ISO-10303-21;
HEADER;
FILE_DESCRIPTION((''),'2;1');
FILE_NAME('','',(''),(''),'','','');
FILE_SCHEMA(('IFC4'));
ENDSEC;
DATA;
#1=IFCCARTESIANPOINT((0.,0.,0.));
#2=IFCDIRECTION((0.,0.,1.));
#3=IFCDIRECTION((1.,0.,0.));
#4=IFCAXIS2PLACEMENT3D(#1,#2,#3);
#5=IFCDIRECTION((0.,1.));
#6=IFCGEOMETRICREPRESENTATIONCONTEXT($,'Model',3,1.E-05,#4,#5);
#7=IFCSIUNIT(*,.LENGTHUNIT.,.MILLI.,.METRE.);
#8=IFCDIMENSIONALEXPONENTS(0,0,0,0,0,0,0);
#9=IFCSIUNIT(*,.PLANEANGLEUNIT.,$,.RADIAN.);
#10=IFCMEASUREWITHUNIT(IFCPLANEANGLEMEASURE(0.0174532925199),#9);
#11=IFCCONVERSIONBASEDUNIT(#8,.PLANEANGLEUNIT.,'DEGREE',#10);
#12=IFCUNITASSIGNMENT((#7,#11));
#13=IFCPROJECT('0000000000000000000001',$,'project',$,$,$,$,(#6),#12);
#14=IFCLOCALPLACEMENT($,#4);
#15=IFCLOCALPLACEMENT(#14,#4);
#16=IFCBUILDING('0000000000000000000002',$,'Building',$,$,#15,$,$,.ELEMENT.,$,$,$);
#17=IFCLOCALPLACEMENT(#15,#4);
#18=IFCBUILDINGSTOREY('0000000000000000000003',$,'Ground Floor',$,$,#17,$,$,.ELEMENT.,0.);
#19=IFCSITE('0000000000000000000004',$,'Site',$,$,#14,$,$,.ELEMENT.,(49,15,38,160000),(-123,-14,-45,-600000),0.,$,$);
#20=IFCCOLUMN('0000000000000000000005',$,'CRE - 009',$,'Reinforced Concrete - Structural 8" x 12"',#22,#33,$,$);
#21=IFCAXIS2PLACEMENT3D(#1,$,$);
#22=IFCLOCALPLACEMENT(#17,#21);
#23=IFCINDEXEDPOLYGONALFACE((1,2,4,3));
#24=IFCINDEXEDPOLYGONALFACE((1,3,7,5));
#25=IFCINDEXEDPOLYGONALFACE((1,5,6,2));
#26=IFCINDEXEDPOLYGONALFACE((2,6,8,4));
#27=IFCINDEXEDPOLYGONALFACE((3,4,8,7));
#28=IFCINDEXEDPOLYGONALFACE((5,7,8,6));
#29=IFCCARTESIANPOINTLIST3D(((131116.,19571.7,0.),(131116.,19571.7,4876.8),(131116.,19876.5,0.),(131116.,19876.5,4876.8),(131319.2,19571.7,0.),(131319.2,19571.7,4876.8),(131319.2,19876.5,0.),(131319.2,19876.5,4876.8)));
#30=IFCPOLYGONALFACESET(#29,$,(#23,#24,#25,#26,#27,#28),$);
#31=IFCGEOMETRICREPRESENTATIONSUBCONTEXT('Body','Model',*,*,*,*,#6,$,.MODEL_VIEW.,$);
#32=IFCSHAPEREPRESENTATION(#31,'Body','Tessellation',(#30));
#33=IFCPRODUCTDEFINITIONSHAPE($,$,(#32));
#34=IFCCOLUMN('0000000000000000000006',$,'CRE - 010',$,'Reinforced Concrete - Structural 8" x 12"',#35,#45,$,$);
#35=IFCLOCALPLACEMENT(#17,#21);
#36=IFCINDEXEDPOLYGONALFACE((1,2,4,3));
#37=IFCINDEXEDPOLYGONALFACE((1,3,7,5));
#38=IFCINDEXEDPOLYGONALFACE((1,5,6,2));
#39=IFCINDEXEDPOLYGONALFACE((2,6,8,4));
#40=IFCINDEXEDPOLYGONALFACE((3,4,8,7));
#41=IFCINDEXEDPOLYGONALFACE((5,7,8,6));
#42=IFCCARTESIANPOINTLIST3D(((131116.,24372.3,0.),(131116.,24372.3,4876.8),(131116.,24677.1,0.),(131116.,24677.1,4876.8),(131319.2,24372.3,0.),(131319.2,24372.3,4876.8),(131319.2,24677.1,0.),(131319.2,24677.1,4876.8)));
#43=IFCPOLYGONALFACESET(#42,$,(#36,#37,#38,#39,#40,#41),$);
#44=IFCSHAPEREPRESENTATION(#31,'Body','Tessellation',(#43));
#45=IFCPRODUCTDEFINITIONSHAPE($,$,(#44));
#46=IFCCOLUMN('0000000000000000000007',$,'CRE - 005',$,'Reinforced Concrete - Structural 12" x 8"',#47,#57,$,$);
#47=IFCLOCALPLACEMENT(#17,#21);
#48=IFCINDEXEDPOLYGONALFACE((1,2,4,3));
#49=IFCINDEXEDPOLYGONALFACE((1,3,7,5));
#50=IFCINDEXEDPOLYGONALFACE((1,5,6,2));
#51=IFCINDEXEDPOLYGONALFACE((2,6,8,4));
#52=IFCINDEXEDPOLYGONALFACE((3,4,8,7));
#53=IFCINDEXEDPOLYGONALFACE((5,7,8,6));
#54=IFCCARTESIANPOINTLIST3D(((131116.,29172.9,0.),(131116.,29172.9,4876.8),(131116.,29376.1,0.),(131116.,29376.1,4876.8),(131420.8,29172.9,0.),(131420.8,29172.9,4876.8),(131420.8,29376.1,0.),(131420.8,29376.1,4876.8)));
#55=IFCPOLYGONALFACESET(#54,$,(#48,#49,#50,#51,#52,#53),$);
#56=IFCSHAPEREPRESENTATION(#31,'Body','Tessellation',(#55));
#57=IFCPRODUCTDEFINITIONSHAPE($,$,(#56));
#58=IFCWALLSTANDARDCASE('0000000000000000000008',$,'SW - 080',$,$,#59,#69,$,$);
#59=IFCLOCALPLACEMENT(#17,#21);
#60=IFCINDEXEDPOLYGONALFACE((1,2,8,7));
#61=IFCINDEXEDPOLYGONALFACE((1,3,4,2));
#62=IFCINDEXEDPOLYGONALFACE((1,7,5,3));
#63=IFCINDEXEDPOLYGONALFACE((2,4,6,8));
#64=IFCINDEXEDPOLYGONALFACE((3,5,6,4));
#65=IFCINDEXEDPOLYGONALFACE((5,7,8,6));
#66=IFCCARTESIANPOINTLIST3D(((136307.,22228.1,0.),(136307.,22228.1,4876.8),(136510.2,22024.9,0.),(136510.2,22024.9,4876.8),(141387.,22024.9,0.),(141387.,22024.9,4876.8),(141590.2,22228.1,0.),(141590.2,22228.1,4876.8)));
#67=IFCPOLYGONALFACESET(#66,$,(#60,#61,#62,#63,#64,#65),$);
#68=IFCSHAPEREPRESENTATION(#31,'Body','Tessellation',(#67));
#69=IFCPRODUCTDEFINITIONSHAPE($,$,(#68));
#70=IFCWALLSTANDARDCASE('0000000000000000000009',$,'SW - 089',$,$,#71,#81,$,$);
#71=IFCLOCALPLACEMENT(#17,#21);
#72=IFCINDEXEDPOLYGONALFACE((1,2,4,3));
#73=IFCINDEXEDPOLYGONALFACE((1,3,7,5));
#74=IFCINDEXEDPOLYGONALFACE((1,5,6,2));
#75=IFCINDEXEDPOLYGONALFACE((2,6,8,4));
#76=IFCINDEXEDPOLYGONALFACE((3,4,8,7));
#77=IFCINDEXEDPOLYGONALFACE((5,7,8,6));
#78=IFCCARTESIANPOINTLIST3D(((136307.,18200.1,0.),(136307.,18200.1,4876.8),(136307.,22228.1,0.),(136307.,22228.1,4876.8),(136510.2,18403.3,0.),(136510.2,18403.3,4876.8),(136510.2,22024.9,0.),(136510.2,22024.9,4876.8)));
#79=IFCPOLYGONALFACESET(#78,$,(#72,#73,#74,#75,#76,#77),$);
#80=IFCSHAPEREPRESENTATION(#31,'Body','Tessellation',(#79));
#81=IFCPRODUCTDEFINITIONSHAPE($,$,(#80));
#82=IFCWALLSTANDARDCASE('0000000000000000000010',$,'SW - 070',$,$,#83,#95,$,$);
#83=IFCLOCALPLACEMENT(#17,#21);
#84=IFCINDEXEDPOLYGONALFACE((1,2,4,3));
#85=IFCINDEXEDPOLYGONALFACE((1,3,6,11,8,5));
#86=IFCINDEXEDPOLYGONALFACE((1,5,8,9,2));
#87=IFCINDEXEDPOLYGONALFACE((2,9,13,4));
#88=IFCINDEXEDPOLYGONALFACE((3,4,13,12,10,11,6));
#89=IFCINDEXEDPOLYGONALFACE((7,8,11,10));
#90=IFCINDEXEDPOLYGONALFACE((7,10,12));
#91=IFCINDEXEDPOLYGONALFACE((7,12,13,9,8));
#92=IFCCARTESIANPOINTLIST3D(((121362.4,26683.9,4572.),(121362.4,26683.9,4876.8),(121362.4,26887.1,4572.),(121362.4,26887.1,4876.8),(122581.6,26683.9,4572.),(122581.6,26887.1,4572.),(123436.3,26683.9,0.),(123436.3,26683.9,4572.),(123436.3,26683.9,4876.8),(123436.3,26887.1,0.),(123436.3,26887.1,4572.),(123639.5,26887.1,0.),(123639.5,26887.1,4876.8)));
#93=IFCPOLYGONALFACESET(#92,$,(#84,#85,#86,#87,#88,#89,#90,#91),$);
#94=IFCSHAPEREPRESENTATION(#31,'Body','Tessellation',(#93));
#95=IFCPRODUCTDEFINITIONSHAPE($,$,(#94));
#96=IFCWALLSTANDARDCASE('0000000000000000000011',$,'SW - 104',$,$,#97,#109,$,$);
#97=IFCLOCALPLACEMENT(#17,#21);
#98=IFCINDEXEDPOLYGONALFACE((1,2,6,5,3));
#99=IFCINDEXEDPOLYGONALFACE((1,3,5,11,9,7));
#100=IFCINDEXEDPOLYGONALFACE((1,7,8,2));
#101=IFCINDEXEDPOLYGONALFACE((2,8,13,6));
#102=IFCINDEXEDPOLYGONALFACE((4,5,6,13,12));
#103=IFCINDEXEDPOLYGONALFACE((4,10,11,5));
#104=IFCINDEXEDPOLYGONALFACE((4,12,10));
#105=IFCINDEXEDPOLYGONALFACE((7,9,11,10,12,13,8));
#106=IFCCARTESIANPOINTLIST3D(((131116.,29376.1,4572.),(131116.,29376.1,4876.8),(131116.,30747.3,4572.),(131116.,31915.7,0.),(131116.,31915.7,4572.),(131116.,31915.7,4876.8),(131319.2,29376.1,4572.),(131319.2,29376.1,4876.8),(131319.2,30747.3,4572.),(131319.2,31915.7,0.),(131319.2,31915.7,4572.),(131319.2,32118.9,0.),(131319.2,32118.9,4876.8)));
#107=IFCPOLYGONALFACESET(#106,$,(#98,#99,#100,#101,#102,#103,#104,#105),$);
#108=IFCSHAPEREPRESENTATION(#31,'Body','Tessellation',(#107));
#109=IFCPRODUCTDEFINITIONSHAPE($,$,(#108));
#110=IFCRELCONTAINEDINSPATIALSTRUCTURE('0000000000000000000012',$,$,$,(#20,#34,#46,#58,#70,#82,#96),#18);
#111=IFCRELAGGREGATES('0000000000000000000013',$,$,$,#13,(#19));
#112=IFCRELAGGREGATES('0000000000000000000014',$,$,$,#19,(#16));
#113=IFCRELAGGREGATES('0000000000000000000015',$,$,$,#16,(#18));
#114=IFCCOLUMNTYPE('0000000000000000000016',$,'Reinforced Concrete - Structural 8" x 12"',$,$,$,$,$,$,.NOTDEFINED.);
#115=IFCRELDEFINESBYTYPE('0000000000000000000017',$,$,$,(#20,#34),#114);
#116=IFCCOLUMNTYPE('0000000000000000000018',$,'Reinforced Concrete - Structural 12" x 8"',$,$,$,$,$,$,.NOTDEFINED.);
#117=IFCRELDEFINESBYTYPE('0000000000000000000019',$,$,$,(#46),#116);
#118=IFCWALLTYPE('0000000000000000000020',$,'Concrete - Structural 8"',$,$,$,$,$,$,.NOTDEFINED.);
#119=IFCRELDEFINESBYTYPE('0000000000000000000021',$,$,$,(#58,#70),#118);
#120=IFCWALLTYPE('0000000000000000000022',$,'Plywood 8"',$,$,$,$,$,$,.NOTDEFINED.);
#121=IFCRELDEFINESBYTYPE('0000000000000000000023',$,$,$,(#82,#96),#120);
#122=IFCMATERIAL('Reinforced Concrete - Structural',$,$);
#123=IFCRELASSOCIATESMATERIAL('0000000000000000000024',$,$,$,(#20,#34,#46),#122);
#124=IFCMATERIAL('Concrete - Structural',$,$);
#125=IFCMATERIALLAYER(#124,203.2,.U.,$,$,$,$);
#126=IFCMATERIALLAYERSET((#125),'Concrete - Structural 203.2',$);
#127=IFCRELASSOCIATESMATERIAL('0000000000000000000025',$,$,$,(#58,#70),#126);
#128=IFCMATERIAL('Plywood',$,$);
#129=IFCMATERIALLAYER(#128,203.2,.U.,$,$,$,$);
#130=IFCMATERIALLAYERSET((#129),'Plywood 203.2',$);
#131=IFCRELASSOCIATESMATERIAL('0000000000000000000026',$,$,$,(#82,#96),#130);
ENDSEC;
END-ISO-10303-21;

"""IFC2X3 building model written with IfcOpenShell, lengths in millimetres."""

from ifc_helpers import new_model, entity, si_unit, converted_unit, direction, frame, origin_with_axes, origin_2d_with_axis, place, context, subcontext, project, spatial, polyline, rectangle, outline, extrude, material, layer, layer_set, layer_usage, type_object, element, save


model = new_model("IFC2X3")

# Units and contexts
model_context = context("Model", 3, precision=1e-05, world=origin_with_axes(), true_north=direction((0.0, 1.0)))
body_context = subcontext(model_context, "Body", "Model", "MODEL_VIEW")
ifc_project = project(units=[si_unit("LENGTHUNIT", "METRE", prefix="MILLI"), converted_unit("PLANEANGLEUNIT", "DEGREE", entity("IfcPlaneAngleMeasure", 0.0174532925199), si_unit("PLANEANGLEUNIT", "RADIAN"), dimensions=[0, 0, 0, 0, 0, 0, 0])], contexts=[model_context])

# Site, building, storey
site_placement = place(None, origin_with_axes())
site = spatial("IfcSite", under=ifc_project, at=site_placement, Name="Site", CompositionType="ELEMENT", RefLatitude=(49, 15, 38, 160000), RefLongitude=(-123, -14, -45, -600000), RefElevation=0.0)
building_placement = place(site_placement, origin_with_axes())
building = spatial("IfcBuilding", under=site, at=building_placement, Name="Building", CompositionType="ELEMENT")
storey_placement = place(building_placement, origin_with_axes())
storey = spatial("IfcBuildingStorey", under=building, at=storey_placement, Name="Ground Floor", CompositionType="ELEMENT", Elevation=0.0)

# Columns
ifc_material_1 = material(Name="Reinforced Concrete - Structural")
column_type_1 = type_object("IfcColumnType", Name="Reinforced Concrete - Structural 8\" x 12\"", PredefinedType="NOTDEFINED")
for number, where, z_axis, x_axis, name in (
    (1, (131217.6, 19724.1, 0.0), (0.0, 0.0, 1.0), (1.0, 0.0, 0.0), "CRE - 009"),
    (2, (131217.6, 24524.7, 0.0), (0.0, 0.0, 1.0), (1.0, 0.0, 0.0), "CRE - 010"),
):
    element("IfcColumn", number, at=place(storey_placement, frame(where, z_axis=z_axis, x_axis=x_axis)), inside=storey, type_object=column_type_1, material=ifc_material_1, Name=name, ObjectType="Reinforced Concrete - Structural 8\" x 12\"", context=body_context, shape_type="SweptSolid", body=[
        extrude(rectangle(XDim=203.2, YDim=304.8, at=origin_2d_with_axis()), origin_with_axes(), (0.0, 0.0, 1.0), 4876.8),
    ])
column_type_2 = type_object("IfcColumnType", Name="Reinforced Concrete - Structural 12\" x 8\"", PredefinedType="NOTDEFINED")
column_placement = place(storey_placement, frame((131268.4, 29274.5, 0.0), z_axis=(0.0, 0.0, 1.0), x_axis=(1.0, 0.0, 0.0)))
element("IfcColumn", 3, at=column_placement, inside=storey, type_object=column_type_2, material=ifc_material_1, Name="CRE - 005", ObjectType="Reinforced Concrete - Structural 12\" x 8\"", context=body_context, shape_type="SweptSolid", body=[
    extrude(rectangle(XDim=304.8, YDim=203.2, at=origin_2d_with_axis()), origin_with_axes(), (0.0, 0.0, 1.0), 4876.8),
])

# Walls
ifc_material_2 = material(Name="Concrete - Structural")
ifc_layer_1 = layer(ifc_material_2, 203.2, ventilated="UNKNOWN")
ifc_layer_set_1 = layer_set([ifc_layer_1], Name="Concrete - Structural 203.2")
ifc_layer_usage_1 = layer_usage(ifc_layer_set_1, "AXIS2", "POSITIVE", 0.0)
wall_type_1 = type_object("IfcWallType", Name="Concrete - Structural 8\"", PredefinedType="NOTDEFINED")
wall_1_placement = place(storey_placement, frame((136510.2, 22024.9, 0.0), z_axis=(0.0, 0.0, 1.0), x_axis=(1.0, 0.0, 0.0)))
element("IfcWallStandardCase", 4, at=wall_1_placement, inside=storey, type_object=wall_type_1, material=ifc_layer_usage_1, Name="SW - 080", context=body_context, shape_type="SweptSolid", body=[
    extrude(outline(polyline([(0.0, 0.0), (4876.8, 0.0), (5080.0, 203.2), (-203.2, 203.2), (0.0, 0.0)])), origin_with_axes(), (0.0, 0.0, 1.0), 4876.8),
])
ifc_layer_usage_2 = layer_usage(ifc_layer_set_1, "AXIS2", "NEGATIVE", 0.0)
wall_2_placement = place(storey_placement, frame((136510.2, 22024.9, 0.0), z_axis=(0.0, 0.0, 1.0), x_axis=(0.0, -1.0, 0.0)))
element("IfcWallStandardCase", 5, at=wall_2_placement, inside=storey, type_object=wall_type_1, material=ifc_layer_usage_2, Name="SW - 089", context=body_context, shape_type="SweptSolid", body=[
    extrude(outline(polyline([(-203.2, -203.2), (3824.8, -203.2), (3621.6, 0.0), (0.0, 0.0), (-203.2, -203.2)])), origin_with_axes(), (0.0, 0.0, 1.0), 4876.8),
])

# Walls, openings
ifc_material_3 = material(Name="Plywood")
ifc_layer_2 = layer(ifc_material_3, 203.2, ventilated="UNKNOWN")
ifc_layer_set_2 = layer_set([ifc_layer_2], Name="Plywood 203.2")
ifc_layer_usage_3 = layer_usage(ifc_layer_set_2, "AXIS2", "POSITIVE", 0.0)
wall_type_2 = type_object("IfcWallType", Name="Plywood 8\"", PredefinedType="NOTDEFINED")
wall_3_placement = place(storey_placement, frame((123639.5, 26887.1, 0.0), z_axis=(0.0, 0.0, 1.0), x_axis=(-1.0, 0.0, 0.0)))
wall_3 = element("IfcWallStandardCase", 6, at=wall_3_placement, inside=storey, type_object=wall_type_2, material=ifc_layer_usage_3, Name="SW - 070", context=body_context, shape_type="SweptSolid", body=[
    extrude(outline(polyline([(0.0, 0.0), (2277.0, 0.0), (2277.0, 203.2), (203.2, 203.2), (0.0, 0.0)])), origin_with_axes(), (0.0, 0.0, 1.0), 4876.8),
])
opening_1_placement = place(wall_3_placement, frame((1667.4, 0.0, 0.0), z_axis=(0.0, 0.0, 1.0), x_axis=(1.0, 0.0, 0.0)))
element("IfcOpeningElement", 7, at=opening_1_placement, cuts=wall_3, context=body_context, shape_type="SweptSolid", body=[
    extrude(rectangle(XDim=1219.2, YDim=4572.0, at=origin_2d_with_axis()), frame((0.0, -203.2, 2286.0), z_axis=(0.0, 1.0, 0.0), x_axis=(1.0, 0.0, 0.0)), (0.0, 0.0, 1.0), 609.6),
])
opening_2_placement = place(wall_3_placement, frame((630.5, 0.0, 0.0), z_axis=(0.0, 0.0, 1.0), x_axis=(1.0, 0.0, 0.0)))
element("IfcOpeningElement", 8, at=opening_2_placement, cuts=wall_3, context=body_context, shape_type="SweptSolid", body=[
    extrude(rectangle(XDim=854.6, YDim=4572.0, at=origin_2d_with_axis()), frame((0.0, -203.2, 2286.0), z_axis=(0.0, 1.0, 0.0), x_axis=(1.0, 0.0, 0.0)), (0.0, 0.0, 1.0), 609.6),
])
ifc_layer_usage_4 = layer_usage(ifc_layer_set_2, "AXIS2", "NEGATIVE", 0.0)
wall_4_placement = place(storey_placement, frame((131116.0, 29376.1, 0.0), z_axis=(0.0, 0.0, 1.0), x_axis=(0.0, 1.0, 0.0)))
wall_4 = element("IfcWallStandardCase", 9, at=wall_4_placement, inside=storey, type_object=wall_type_2, material=ifc_layer_usage_4, Name="SW - 104", context=body_context, shape_type="SweptSolid", body=[
    extrude(outline(polyline([(0.0, -203.2), (2742.9, -203.2), (2539.7, 0.0), (0.0, 0.0), (0.0, -203.2)])), origin_with_axes(), (0.0, 0.0, 1.0), 4876.8),
])
opening_3_placement = place(wall_4_placement, frame((685.5, 0.0, 0.0), z_axis=(0.0, 0.0, 1.0), x_axis=(1.0, 0.0, 0.0)))
element("IfcOpeningElement", 10, at=opening_3_placement, cuts=wall_4, context=body_context, shape_type="SweptSolid", body=[
    extrude(rectangle(XDim=1371.6, YDim=4572.0, at=origin_2d_with_axis()), frame((0.0, 203.2, 2286.0), z_axis=(0.0, 1.0, 0.0), x_axis=(1.0, 0.0, 0.0)), (0.0, 0.0, -1.0), 609.6),
])
opening_4_placement = place(wall_4_placement, frame((1955.5, 0.0, 0.0), z_axis=(0.0, 0.0, 1.0), x_axis=(1.0, 0.0, 0.0)))
element("IfcOpeningElement", 11, at=opening_4_placement, cuts=wall_4, context=body_context, shape_type="SweptSolid", body=[
    extrude(rectangle(XDim=1168.4, YDim=4572.0, at=origin_2d_with_axis()), frame((0.0, 203.2, 2286.0), z_axis=(0.0, -1.0, 0.0), x_axis=(-1.0, 0.0, 0.0)), (0.0, 0.0, 1.0), 609.6),
])

save(model, "model.ifc")
